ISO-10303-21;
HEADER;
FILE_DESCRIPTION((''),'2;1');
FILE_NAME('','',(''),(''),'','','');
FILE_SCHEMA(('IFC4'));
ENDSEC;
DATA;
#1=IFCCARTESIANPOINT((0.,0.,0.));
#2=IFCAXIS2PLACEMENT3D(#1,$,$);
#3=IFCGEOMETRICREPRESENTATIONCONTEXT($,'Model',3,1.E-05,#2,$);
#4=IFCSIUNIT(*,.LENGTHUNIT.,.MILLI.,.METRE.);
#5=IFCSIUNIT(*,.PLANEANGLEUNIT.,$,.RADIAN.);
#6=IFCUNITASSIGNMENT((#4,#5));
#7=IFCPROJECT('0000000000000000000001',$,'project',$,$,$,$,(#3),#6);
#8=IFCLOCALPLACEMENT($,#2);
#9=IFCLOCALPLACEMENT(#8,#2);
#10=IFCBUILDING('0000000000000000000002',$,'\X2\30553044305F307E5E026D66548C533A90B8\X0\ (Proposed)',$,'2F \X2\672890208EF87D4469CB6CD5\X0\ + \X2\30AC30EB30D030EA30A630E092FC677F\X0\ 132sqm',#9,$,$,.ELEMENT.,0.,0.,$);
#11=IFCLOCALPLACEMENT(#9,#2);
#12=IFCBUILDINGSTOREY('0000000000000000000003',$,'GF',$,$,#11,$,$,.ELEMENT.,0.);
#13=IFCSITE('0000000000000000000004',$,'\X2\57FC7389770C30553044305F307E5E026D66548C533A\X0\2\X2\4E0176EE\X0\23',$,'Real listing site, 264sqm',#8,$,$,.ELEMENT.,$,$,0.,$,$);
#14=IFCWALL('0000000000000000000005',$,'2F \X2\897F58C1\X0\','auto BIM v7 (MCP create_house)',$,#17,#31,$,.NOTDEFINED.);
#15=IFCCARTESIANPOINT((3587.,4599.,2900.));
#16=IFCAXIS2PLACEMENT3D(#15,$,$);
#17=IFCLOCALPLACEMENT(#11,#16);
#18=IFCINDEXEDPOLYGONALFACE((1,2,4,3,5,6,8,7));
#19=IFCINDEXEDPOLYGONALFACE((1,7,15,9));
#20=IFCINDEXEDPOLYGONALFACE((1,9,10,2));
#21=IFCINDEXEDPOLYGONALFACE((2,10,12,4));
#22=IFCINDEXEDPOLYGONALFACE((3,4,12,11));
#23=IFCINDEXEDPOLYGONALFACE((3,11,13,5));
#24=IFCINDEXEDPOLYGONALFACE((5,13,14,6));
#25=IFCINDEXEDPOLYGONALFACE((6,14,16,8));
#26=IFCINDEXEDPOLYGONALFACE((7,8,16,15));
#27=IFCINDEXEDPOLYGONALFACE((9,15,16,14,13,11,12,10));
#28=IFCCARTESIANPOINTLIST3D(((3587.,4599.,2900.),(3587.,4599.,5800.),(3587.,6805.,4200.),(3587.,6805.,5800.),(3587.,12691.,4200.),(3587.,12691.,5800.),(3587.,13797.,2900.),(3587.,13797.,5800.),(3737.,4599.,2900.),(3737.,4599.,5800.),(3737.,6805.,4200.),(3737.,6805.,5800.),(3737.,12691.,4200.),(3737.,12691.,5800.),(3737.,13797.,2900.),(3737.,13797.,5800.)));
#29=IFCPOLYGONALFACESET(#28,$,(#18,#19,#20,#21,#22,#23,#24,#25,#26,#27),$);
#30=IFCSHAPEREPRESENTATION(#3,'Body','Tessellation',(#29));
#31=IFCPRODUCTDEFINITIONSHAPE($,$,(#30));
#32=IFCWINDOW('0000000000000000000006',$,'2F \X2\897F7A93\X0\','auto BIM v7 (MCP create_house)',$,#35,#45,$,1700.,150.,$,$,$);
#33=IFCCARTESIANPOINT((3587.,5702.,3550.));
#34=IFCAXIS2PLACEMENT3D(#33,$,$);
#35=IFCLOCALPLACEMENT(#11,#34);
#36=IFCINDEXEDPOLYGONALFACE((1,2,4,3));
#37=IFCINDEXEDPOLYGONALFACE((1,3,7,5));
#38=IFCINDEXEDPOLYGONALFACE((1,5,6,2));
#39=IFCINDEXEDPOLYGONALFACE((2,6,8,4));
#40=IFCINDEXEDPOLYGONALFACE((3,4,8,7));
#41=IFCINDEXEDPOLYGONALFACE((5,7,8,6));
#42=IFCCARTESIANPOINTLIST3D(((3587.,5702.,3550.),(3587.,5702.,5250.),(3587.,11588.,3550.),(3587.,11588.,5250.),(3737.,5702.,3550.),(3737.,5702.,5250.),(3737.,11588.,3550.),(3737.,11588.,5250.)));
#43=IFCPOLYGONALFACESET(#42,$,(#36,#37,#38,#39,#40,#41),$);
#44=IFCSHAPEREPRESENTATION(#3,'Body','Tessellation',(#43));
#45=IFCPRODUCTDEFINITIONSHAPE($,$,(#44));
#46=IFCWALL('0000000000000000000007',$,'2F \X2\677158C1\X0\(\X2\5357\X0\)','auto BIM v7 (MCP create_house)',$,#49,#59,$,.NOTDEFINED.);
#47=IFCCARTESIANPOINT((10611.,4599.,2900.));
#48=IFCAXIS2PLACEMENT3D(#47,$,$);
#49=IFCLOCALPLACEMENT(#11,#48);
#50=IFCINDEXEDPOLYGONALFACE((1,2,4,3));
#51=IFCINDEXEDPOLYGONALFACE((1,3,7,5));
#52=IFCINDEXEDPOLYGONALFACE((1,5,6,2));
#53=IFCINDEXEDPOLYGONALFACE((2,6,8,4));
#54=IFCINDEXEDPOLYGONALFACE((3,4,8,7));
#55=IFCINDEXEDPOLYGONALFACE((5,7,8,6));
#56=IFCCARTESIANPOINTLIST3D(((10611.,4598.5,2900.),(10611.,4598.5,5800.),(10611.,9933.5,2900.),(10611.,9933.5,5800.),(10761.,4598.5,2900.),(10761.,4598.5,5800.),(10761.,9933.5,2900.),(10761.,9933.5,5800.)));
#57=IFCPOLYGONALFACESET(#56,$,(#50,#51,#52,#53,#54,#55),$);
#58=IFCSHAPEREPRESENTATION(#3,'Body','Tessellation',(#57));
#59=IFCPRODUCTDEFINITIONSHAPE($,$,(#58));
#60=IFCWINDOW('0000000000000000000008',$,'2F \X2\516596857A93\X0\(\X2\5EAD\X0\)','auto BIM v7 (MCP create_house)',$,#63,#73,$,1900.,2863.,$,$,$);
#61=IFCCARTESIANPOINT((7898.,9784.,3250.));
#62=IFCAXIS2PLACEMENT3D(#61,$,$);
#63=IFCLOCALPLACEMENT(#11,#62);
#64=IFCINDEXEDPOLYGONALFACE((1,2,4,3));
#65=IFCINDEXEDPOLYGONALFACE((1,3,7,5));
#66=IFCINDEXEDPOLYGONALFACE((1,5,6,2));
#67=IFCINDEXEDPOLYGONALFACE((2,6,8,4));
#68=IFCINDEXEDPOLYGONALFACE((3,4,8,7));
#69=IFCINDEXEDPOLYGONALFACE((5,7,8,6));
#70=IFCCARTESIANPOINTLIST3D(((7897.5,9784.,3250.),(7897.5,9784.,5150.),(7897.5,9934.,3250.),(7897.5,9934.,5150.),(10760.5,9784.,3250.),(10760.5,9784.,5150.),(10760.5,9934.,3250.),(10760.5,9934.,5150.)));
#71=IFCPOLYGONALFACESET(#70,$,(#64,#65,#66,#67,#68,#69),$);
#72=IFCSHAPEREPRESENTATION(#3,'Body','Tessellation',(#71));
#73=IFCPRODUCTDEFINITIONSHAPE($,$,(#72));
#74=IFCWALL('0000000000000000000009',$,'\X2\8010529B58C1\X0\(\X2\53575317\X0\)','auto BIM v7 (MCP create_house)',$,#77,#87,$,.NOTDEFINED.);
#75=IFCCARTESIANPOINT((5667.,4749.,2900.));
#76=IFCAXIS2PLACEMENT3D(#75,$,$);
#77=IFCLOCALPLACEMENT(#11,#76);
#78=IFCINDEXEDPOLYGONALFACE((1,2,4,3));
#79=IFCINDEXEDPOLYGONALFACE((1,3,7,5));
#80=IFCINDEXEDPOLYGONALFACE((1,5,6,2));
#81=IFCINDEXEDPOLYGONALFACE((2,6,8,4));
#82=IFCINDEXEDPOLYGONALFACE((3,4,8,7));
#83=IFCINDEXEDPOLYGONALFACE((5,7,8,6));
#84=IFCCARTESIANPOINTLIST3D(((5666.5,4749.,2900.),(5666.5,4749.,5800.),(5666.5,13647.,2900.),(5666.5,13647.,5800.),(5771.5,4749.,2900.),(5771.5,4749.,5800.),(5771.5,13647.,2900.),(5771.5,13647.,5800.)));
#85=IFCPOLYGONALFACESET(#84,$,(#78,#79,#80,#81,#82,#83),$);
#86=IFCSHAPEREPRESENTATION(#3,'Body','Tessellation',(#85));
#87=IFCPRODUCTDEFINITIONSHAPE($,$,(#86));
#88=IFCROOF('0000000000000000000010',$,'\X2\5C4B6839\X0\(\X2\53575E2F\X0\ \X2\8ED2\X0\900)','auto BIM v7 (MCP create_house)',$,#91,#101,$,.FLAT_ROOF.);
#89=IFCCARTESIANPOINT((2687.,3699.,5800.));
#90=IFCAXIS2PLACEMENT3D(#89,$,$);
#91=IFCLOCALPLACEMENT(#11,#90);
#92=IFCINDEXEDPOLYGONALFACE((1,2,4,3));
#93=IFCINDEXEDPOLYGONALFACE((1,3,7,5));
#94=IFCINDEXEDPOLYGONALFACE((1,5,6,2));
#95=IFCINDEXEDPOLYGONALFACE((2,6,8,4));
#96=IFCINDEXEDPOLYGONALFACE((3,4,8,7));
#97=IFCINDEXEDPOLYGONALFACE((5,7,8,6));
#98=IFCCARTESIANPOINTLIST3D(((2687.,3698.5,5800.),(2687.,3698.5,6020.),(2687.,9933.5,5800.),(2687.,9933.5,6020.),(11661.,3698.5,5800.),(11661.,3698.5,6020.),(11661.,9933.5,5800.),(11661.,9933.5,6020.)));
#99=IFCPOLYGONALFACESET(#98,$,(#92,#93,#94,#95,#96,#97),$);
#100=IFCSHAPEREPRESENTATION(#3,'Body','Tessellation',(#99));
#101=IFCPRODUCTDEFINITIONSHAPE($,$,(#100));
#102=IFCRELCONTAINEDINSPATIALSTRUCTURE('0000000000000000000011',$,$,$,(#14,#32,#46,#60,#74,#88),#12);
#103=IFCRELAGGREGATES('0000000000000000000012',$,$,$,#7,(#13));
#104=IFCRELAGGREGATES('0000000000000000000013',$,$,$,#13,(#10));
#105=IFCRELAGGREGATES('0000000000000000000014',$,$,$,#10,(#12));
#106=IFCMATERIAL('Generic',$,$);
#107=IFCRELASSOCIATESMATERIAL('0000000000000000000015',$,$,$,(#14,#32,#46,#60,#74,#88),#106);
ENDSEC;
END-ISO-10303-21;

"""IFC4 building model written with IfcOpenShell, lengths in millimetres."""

from ifc_helpers import new_model, si_unit, frame, frame_2d, origin, place, context, project, spatial, rectangle, extrude, material, element, fill, save


model = new_model("IFC4")

# Units and contexts
model_context = context("Model", 3, precision=1e-05, world=origin())
ifc_project = project(units=[si_unit("LENGTHUNIT", "METRE", prefix="MILLI"), si_unit("PLANEANGLEUNIT", "RADIAN")], contexts=[model_context])

# Site, building, storey
site_placement = place(None, origin())
site = spatial("IfcSite", under=ifc_project, at=site_placement, Name="埼玉県さいたま市浦和区2丁目23", ObjectType="Real listing site, 264sqm", CompositionType="ELEMENT", RefElevation=0.0)
building_placement = place(site_placement, origin())
building = spatial("IfcBuilding", under=site, at=building_placement, Name="さいたま市浦和区邸 (Proposed)", ObjectType="2F 木造軸組構法 + ガルバリウム鋼板 132sqm", CompositionType="ELEMENT", ElevationOfRefHeight=0.0, ElevationOfTerrain=0.0)
storey_placement = place(building_placement, origin())
storey = spatial("IfcBuildingStorey", under=building, at=storey_placement, Name="GF", CompositionType="ELEMENT", Elevation=0.0)

# Shared definitions
ifc_material = material(Name="Generic")

# Walls, openings, windows
wall_1_placement = place(storey_placement, frame((3587.0, 4599.0, 2900.0)))
wall_1 = element("IfcWall", 1, at=wall_1_placement, inside=storey, material=ifc_material, Name="2F 西壁", Description="auto BIM v7 (MCP create_house)", PredefinedType="NOTDEFINED", context=model_context, shape_type="SweptSolid", body=[
    extrude(rectangle(XDim=150.0, YDim=9198.0, at=frame_2d((75.0, 4599.0))), frame((3587.0, 4599.0, 2900.0)), (0.0, 0.0, 1.0), 2900.0),
])
opening_1_placement = place(storey_placement, frame((3587.0, 5702.0, 3550.0)))
opening_1 = element("IfcOpeningElement", 2, at=opening_1_placement, cuts=wall_1, PredefinedType="NOTDEFINED", context=model_context, shape_type="SweptSolid", body=[
    extrude(rectangle(XDim=150.0, YDim=5886.0, at=frame_2d((75.0, 2943.0))), frame((3587.0, 5702.0, 3550.0)), (0.0, 0.0, 1.0), 1700.0),
])
window_1_placement = place(storey_placement, frame((3587.0, 5702.0, 3550.0)))
window_1 = element("IfcWindow", 3, at=window_1_placement, inside=storey, material=ifc_material, Name="2F 西窓", Description="auto BIM v7 (MCP create_house)", OverallHeight=1700.0, OverallWidth=150.0, context=model_context, shape_type="SweptSolid", body=[
    extrude(rectangle(XDim=150.0, YDim=5886.0, at=frame_2d((75.0, 2943.0))), frame((3587.0, 5702.0, 3550.0)), (0.0, 0.0, 1.0), 1700.0),
])
fill(opening_1, window_1)
wall_2_placement = place(storey_placement, frame((10611.0, 4599.0, 2900.0)))
wall_2 = element("IfcWall", 4, at=wall_2_placement, inside=storey, material=ifc_material, Name="2F 東壁(南)", Description="auto BIM v7 (MCP create_house)", PredefinedType="NOTDEFINED", context=model_context, shape_type="SweptSolid", body=[
    extrude(rectangle(XDim=150.0, YDim=5335.0, at=frame_2d((75.0, 2667.0))), frame((10611.0, 4599.0, 2900.0)), (0.0, 0.0, 1.0), 2900.0),
])
opening_2_placement = place(storey_placement, frame((7898.0, 9784.0, 3250.0)))
opening_2 = element("IfcOpeningElement", 5, at=opening_2_placement, cuts=wall_2, PredefinedType="NOTDEFINED", context=model_context, shape_type="SweptSolid", body=[
    extrude(rectangle(XDim=2863.0, YDim=150.0, at=frame_2d((1431.0, 75.0))), frame((7898.0, 9784.0, 3250.0)), (0.0, 0.0, 1.0), 1900.0),
])
window_2_placement = place(storey_placement, frame((7898.0, 9784.0, 3250.0)))
window_2 = element("IfcWindow", 6, at=window_2_placement, inside=storey, material=ifc_material, Name="2F 入隅窓(庭)", Description="auto BIM v7 (MCP create_house)", OverallHeight=1900.0, OverallWidth=2863.0, context=model_context, shape_type="SweptSolid", body=[
    extrude(rectangle(XDim=2863.0, YDim=150.0, at=frame_2d((1431.0, 75.0))), frame((7898.0, 9784.0, 3250.0)), (0.0, 0.0, 1.0), 1900.0),
])
fill(opening_2, window_2)

# Wall
wall_3_placement = place(storey_placement, frame((5667.0, 4749.0, 2900.0)))
element("IfcWall", 7, at=wall_3_placement, inside=storey, material=ifc_material, Name="耐力壁(南北)", Description="auto BIM v7 (MCP create_house)", PredefinedType="NOTDEFINED", context=model_context, shape_type="SweptSolid", body=[
    extrude(rectangle(XDim=105.0, YDim=8898.0, at=frame_2d((52.0, 4449.0))), frame((5667.0, 4749.0, 2900.0)), (0.0, 0.0, 1.0), 2900.0),
])

# Roof
for number, where, name in (
    (8, (2687.0, 3699.0, 5800.0), "屋根(南帯 軒900)"),
):
    element("IfcRoof", number, at=place(storey_placement, frame(where)), inside=storey, material=ifc_material, Name=name, Description="auto BIM v7 (MCP create_house)", PredefinedType="FLAT_ROOF", context=model_context, shape_type="SweptSolid", body=[
        extrude(rectangle(XDim=8974.0, YDim=6235.0, at=frame_2d((4487.0, 3117.0))), frame((2687.0, 3699.0, 5800.0)), (0.0, 0.0, 1.0), 220.0),
    ])

save(model, "model.ifc")
